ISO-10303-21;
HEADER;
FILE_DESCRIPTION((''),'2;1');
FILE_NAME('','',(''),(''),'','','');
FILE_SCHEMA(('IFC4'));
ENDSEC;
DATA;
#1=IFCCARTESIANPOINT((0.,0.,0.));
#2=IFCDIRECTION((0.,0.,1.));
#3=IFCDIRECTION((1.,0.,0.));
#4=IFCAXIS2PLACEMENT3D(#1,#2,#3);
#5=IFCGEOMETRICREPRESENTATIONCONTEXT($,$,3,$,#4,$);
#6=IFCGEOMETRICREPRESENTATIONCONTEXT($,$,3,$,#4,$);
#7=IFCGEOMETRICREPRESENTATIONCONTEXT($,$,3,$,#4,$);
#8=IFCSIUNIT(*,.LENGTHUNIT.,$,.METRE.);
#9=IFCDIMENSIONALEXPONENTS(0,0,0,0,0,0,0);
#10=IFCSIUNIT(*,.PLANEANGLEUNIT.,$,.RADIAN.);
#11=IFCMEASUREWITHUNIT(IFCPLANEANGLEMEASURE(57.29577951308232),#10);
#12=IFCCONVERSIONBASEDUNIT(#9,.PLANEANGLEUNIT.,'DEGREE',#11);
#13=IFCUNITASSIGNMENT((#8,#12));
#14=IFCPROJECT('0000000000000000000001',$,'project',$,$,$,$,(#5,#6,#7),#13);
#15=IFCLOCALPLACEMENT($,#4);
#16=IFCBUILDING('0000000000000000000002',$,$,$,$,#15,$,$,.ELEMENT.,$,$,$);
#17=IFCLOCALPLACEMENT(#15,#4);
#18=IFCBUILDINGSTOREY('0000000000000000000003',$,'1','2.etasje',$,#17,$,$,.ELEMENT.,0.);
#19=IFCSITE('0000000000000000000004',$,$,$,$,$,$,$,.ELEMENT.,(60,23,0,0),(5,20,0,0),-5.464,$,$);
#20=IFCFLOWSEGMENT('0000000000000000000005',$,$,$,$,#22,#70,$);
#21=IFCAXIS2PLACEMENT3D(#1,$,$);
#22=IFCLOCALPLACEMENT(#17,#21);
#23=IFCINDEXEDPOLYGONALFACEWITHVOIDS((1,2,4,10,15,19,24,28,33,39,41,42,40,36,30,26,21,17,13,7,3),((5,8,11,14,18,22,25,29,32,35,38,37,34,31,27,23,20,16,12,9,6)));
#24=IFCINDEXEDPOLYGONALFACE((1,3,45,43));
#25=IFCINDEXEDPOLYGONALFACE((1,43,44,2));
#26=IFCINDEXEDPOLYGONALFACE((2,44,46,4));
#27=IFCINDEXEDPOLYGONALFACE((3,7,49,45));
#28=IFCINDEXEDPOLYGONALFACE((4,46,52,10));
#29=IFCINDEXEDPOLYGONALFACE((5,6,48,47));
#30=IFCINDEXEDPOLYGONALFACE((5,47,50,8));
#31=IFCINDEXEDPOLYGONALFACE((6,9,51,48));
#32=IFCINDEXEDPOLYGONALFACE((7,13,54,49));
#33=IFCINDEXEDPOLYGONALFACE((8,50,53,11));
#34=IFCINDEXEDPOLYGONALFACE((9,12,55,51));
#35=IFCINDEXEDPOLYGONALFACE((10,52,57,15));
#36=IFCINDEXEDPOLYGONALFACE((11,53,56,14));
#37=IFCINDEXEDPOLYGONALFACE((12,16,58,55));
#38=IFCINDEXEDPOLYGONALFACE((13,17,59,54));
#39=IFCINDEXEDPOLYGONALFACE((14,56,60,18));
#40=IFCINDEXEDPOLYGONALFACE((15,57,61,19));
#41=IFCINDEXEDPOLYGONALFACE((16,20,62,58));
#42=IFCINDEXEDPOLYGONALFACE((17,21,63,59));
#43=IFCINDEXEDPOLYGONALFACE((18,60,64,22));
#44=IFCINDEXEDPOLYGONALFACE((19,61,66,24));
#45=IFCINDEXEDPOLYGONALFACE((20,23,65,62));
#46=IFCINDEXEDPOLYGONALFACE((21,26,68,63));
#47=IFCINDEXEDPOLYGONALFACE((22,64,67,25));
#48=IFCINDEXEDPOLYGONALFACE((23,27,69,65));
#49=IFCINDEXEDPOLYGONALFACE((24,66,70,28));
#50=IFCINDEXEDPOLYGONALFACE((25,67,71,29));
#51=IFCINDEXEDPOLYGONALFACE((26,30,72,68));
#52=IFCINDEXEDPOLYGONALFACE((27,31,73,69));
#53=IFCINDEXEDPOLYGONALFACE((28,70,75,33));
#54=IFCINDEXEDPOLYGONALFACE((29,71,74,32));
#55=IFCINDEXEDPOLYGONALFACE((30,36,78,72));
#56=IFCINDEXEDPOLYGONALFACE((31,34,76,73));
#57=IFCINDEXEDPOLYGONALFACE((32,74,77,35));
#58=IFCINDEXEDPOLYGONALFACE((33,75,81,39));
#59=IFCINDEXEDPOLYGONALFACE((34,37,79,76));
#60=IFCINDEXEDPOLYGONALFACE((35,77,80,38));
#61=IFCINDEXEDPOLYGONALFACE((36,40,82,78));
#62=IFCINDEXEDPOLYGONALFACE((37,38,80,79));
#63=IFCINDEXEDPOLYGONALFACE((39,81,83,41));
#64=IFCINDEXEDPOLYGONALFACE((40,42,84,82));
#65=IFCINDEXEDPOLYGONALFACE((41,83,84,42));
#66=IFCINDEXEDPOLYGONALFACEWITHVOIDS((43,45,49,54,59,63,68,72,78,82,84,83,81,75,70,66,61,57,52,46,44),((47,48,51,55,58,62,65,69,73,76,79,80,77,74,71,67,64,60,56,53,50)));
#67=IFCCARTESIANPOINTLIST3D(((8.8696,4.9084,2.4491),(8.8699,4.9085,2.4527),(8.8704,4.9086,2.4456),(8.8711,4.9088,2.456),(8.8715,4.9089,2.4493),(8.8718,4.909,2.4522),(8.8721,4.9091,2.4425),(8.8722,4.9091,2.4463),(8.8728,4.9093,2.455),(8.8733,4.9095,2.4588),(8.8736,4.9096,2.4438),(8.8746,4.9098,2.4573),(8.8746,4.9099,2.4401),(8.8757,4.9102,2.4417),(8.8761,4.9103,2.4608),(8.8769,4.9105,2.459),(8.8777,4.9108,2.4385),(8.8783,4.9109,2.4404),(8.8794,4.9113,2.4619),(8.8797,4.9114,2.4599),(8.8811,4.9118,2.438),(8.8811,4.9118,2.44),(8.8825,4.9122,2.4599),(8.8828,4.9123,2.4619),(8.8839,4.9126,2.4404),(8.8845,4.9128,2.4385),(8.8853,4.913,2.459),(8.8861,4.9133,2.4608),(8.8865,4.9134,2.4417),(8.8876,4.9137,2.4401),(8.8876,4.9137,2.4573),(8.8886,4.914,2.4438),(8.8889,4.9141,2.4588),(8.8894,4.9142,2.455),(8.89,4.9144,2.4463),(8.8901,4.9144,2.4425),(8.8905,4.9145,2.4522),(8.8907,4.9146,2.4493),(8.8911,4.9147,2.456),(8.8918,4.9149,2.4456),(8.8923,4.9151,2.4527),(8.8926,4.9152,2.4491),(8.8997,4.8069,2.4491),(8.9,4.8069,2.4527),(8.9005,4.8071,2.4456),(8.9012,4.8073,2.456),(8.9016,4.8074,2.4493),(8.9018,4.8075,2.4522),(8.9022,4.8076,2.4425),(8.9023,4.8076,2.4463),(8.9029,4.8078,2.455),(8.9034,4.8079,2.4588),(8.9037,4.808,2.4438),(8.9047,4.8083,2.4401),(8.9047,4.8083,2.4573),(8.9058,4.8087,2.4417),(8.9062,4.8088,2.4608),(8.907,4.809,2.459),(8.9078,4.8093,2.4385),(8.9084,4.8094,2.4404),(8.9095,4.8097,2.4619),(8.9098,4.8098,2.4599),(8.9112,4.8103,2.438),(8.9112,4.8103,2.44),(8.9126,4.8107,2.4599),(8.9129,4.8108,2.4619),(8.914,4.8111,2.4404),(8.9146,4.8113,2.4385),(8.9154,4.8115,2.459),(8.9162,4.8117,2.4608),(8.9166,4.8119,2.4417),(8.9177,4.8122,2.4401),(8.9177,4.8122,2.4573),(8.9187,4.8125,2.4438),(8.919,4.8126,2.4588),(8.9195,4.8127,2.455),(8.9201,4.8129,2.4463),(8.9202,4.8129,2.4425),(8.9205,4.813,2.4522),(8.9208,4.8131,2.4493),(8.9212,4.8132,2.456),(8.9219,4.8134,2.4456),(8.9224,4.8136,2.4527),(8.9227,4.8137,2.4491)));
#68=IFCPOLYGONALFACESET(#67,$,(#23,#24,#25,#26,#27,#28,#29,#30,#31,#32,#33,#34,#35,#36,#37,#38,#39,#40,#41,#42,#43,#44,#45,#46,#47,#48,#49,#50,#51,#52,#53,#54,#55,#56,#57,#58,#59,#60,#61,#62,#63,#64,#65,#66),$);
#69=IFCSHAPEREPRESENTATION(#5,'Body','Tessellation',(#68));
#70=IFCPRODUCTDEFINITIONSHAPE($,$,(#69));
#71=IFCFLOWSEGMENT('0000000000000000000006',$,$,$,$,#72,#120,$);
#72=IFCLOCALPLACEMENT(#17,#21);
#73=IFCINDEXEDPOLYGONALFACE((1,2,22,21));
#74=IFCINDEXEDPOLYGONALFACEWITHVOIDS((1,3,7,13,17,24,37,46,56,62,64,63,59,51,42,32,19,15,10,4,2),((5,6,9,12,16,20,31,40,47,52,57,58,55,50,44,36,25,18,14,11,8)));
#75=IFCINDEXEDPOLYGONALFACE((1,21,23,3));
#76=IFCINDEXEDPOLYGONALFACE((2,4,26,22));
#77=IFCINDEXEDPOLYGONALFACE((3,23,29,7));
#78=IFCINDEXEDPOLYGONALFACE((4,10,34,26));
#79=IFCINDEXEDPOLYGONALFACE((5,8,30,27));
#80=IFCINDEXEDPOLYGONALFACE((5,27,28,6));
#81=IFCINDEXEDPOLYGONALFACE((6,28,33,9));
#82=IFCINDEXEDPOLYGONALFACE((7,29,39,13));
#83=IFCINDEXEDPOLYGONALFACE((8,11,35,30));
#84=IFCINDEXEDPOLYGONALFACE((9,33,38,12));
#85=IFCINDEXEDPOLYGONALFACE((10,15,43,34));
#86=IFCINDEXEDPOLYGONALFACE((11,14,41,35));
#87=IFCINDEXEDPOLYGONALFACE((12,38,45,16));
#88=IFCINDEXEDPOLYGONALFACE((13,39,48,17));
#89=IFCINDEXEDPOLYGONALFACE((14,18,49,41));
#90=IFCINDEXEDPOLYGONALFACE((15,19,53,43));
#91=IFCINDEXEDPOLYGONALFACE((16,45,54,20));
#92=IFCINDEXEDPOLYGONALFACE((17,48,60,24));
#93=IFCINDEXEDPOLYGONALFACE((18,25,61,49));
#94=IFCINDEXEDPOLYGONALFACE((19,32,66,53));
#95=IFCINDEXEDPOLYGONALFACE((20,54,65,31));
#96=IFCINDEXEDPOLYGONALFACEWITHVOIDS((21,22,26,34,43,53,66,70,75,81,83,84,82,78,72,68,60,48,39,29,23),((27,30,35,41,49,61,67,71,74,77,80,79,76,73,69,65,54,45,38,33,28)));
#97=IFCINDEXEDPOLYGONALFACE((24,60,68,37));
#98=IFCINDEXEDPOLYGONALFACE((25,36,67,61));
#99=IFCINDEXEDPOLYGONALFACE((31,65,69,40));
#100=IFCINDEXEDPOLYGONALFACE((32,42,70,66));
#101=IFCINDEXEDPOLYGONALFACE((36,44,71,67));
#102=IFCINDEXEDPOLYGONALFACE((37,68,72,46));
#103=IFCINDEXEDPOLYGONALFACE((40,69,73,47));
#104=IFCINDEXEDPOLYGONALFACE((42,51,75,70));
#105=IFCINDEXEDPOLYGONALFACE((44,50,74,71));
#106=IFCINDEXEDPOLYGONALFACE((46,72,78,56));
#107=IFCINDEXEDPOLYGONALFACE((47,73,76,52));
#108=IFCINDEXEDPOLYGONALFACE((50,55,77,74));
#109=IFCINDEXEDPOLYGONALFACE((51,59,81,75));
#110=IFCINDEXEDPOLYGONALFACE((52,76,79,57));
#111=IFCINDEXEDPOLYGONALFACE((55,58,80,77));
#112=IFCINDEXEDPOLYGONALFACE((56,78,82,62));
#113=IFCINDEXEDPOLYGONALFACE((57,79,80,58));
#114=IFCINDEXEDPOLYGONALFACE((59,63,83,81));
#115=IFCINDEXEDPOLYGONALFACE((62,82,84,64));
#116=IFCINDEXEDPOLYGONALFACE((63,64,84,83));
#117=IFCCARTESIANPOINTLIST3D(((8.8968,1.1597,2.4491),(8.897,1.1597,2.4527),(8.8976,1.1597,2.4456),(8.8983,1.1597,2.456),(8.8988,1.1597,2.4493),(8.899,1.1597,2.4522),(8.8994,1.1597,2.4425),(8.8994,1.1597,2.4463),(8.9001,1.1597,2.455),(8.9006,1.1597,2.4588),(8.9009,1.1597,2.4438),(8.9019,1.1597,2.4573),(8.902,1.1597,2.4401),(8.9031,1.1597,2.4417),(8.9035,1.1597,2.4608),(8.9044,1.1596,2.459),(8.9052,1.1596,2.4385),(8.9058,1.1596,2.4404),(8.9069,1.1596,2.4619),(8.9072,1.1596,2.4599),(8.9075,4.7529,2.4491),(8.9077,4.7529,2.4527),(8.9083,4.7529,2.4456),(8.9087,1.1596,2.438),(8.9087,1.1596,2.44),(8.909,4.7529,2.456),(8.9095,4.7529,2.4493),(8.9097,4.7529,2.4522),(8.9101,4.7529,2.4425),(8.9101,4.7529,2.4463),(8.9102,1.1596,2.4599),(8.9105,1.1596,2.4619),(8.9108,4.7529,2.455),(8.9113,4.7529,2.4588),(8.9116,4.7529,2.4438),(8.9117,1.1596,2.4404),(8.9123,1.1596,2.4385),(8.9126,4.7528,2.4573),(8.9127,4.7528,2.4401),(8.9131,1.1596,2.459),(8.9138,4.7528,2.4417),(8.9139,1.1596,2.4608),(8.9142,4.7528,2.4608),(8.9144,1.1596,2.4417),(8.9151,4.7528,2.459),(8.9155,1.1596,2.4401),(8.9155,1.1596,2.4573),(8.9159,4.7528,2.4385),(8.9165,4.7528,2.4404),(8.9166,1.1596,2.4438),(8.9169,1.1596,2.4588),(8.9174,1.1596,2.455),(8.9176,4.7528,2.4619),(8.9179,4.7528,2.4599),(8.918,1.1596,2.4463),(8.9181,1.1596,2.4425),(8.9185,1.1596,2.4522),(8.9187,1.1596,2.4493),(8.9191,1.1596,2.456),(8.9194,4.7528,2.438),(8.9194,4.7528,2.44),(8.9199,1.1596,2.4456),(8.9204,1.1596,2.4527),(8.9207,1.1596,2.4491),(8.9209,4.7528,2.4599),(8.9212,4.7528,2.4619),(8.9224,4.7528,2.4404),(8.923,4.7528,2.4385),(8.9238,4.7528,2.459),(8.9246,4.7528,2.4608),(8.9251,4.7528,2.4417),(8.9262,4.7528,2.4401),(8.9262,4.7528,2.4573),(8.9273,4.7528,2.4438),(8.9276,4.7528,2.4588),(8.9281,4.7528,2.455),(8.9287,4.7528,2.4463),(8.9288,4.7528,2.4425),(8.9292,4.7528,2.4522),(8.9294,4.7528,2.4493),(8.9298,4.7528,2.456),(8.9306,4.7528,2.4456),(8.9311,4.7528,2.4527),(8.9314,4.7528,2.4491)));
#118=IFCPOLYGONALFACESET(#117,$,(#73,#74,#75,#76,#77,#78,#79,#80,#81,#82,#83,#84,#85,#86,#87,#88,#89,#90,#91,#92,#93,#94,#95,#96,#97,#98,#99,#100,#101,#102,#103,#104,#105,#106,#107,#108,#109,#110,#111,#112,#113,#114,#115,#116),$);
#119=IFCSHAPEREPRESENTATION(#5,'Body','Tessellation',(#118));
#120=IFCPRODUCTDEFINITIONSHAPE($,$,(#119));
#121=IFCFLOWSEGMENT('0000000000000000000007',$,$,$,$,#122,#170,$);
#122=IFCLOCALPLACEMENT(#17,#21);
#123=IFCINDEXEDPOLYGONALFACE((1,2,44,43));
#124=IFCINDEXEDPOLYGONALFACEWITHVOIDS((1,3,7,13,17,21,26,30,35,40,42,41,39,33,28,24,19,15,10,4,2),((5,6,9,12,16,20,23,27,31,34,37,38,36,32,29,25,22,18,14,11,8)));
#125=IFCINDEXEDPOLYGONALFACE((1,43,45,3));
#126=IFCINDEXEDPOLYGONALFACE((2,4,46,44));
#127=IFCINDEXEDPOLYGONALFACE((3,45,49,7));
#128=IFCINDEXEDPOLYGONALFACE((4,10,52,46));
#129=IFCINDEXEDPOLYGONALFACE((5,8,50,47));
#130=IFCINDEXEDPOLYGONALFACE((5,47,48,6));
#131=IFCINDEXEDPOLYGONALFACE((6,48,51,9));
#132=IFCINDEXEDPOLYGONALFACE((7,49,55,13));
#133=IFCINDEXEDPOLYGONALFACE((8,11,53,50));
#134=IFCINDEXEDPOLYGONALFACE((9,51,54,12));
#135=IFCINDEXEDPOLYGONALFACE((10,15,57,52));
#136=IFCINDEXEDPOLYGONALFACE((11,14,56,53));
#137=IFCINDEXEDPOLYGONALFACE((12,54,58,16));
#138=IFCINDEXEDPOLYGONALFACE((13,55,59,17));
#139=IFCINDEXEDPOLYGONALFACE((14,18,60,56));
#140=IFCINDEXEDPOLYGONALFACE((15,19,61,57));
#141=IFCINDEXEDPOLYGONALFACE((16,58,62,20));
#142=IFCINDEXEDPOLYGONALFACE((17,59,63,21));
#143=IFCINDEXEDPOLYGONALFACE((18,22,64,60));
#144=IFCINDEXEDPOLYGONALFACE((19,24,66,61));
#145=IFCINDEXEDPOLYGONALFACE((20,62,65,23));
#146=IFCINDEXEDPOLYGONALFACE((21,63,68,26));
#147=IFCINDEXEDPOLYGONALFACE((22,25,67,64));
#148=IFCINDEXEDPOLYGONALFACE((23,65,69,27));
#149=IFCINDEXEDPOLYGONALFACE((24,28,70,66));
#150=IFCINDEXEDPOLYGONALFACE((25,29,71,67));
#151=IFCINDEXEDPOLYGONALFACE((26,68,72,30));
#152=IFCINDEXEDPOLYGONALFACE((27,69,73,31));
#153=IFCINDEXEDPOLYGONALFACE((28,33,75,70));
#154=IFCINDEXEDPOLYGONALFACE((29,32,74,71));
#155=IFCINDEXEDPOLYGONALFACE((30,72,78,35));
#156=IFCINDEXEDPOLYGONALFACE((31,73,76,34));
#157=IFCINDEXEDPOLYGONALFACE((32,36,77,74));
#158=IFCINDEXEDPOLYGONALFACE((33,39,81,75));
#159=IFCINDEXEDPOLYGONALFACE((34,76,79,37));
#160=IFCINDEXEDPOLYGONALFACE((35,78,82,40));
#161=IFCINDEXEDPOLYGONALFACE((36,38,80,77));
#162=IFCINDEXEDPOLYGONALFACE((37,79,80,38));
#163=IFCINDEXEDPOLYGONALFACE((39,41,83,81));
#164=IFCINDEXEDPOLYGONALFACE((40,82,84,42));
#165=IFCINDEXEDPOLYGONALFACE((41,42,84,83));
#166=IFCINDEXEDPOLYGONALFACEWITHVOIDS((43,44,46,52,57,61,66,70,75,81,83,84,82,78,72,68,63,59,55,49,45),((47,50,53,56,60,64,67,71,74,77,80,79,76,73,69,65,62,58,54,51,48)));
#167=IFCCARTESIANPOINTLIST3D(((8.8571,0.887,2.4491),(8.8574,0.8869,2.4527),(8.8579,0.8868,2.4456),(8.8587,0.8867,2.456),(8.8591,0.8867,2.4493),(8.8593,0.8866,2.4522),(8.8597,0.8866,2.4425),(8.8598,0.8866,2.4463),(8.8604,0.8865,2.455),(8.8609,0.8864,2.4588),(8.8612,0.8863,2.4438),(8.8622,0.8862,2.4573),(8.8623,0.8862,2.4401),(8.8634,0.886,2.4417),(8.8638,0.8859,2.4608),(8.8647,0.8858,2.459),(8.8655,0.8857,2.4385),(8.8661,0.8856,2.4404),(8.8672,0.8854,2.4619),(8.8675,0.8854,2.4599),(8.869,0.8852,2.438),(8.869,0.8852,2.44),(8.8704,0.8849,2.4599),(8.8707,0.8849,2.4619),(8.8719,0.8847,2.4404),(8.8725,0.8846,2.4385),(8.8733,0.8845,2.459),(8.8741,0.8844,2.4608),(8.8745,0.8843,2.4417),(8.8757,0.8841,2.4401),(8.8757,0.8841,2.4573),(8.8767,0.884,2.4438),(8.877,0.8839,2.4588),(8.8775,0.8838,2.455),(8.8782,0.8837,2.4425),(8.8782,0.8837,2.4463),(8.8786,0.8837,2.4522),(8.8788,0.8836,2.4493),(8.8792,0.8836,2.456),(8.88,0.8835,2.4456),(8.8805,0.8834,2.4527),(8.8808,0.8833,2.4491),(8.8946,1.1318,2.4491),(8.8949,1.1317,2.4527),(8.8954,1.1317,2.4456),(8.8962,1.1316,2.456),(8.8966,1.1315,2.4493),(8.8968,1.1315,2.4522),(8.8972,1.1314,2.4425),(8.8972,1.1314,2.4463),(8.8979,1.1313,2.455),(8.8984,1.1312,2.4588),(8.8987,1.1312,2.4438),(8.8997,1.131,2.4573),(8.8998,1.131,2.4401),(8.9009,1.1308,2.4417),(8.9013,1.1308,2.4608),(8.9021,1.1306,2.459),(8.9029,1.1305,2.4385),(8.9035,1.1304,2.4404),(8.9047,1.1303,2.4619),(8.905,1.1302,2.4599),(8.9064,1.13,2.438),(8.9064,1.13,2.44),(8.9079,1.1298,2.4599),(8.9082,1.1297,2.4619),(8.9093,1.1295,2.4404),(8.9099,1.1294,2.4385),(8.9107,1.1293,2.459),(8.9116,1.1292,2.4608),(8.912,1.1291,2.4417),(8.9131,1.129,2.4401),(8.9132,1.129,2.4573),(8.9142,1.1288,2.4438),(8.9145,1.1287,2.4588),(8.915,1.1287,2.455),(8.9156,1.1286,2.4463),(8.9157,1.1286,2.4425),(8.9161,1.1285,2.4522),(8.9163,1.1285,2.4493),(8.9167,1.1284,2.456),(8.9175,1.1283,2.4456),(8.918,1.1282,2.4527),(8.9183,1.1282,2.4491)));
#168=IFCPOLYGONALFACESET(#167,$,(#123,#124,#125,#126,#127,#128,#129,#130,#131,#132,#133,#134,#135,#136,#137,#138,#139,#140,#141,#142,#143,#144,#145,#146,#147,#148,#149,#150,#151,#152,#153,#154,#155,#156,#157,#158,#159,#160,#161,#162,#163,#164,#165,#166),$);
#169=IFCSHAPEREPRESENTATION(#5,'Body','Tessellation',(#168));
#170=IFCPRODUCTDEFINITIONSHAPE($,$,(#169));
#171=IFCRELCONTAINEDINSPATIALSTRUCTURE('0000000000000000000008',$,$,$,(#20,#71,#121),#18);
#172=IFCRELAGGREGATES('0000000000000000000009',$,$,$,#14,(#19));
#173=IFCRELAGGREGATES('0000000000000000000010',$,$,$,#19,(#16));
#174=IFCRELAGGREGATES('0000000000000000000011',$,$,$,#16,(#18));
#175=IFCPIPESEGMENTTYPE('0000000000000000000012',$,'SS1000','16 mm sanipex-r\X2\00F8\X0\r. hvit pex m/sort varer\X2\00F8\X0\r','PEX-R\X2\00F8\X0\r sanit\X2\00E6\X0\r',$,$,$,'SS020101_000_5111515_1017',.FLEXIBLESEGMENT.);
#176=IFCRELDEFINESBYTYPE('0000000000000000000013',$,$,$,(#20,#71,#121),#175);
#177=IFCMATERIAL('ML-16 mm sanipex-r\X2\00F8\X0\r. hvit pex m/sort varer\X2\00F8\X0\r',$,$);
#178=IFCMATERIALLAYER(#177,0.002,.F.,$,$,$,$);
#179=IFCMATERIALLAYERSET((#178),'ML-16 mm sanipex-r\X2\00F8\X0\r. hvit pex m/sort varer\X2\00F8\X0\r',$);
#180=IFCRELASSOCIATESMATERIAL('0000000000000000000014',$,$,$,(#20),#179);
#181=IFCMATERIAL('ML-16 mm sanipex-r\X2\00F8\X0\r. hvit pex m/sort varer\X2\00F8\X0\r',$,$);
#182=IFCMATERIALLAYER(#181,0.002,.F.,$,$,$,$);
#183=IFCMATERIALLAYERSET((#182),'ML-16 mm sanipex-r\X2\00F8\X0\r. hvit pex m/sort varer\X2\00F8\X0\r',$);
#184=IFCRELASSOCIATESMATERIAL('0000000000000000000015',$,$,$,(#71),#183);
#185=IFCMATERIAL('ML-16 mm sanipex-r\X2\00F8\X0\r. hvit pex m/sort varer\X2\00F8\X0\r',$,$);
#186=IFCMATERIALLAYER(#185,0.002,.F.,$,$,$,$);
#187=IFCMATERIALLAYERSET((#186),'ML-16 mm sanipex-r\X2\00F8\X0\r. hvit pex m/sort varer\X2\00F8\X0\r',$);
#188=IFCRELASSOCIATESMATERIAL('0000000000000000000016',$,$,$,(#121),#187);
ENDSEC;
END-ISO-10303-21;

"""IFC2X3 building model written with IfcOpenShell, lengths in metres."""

from ifc_helpers import new_model, entity, si_unit, converted_unit, frame, origin_with_axes, origin_2d_with_axis, place, context, project, spatial, hollow_circle, extrude, material, layer, layer_set, layer_usage, type_object, element, save


model = new_model("IFC2X3")

# Units and contexts
context_of_model_1 = context(None, 3, world=origin_with_axes())
context_of_model_2 = context(None, 3, world=origin_with_axes())
context_of_model_3 = context(None, 3, world=origin_with_axes())
ifc_project = project(units=[si_unit("LENGTHUNIT", "METRE"), converted_unit("PLANEANGLEUNIT", "DEGREE", entity("IfcPlaneAngleMeasure", 57.29577951308232), si_unit("PLANEANGLEUNIT", "RADIAN"), dimensions=[0, 0, 0, 0, 0, 0, 0])], contexts=[context_of_model_1, context_of_model_2, context_of_model_3])

# Site, building, storey
site = spatial("IfcSite", under=ifc_project, CompositionType="ELEMENT", RefLatitude=(60, 23, 0, 0), RefLongitude=(5, 20, 0, 0), RefElevation=-5.464)
building_placement = place(None, origin_with_axes())
building = spatial("IfcBuilding", under=site, at=building_placement, CompositionType="ELEMENT")
storey_placement = place(building_placement, origin_with_axes())
storey = spatial("IfcBuildingStorey", under=building, at=storey_placement, Name="1", Description="2.etasje", CompositionType="ELEMENT", Elevation=0.0)

# Flow segments
pipe_segment_type_1 = type_object("IfcPipeSegmentType", Name="SS1000", Description="16 mm sanipex-rør. hvit pex m/sort varerør", ApplicableOccurrence="PEX-Rør sanitær", ElementType="SS020101_000_5111515_1017", PredefinedType="FLEXIBLESEGMENT")
ifc_material_1 = material(Name="ML-16 mm sanipex-rør. hvit pex m/sort varerør")
ifc_layer_1 = layer(ifc_material_1, 0.002, ventilated=False)
ifc_layer_set_1 = layer_set([ifc_layer_1], Name="ML-16 mm sanipex-rør. hvit pex m/sort varerør")
ifc_layer_usage_1 = layer_usage(ifc_layer_set_1, "AXIS2", "POSITIVE", 0.0)
flow_segment_1_placement = place(storey_placement, frame((8.8811, 4.9118, 2.45), z_axis=(0.284164, -0.958776, 0.0), x_axis=(0.0, 0.0, -1.0)))
element("IfcFlowSegment", 1, at=flow_segment_1_placement, inside=storey, type_object=pipe_segment_type_1, material=ifc_layer_usage_1, context=context_of_model_1, shape_type="SweptSolid", body=[
    extrude(hollow_circle(Radius=0.012, WallThickness=0.002, at=origin_2d_with_axis()), origin_with_axes(), (0.0, 0.0, 1.0), 0.1059),
])
ifc_material_2 = material(Name="ML-16 mm sanipex-rør. hvit pex m/sort varerør")
ifc_layer_2 = layer(ifc_material_2, 0.002, ventilated=False)
ifc_layer_set_2 = layer_set([ifc_layer_2], Name="ML-16 mm sanipex-rør. hvit pex m/sort varerør")
ifc_layer_usage_2 = layer_usage(ifc_layer_set_2, "AXIS2", "POSITIVE", 0.0)
flow_segment_2_placement = place(storey_placement, frame((8.9194, 4.7528, 2.45), z_axis=(-0.002978, -0.999996, 0.0), x_axis=(0.0, 0.0, -1.0)))
element("IfcFlowSegment", 2, at=flow_segment_2_placement, inside=storey, type_object=pipe_segment_type_1, material=ifc_layer_usage_2, context=context_of_model_1, shape_type="SweptSolid", body=[
    extrude(hollow_circle(Radius=0.012, WallThickness=0.002, at=origin_2d_with_axis()), origin_with_axes(), (0.0, 0.0, 1.0), 3.5932),
])
ifc_material_3 = material(Name="ML-16 mm sanipex-rør. hvit pex m/sort varerør")
ifc_layer_3 = layer(ifc_material_3, 0.002, ventilated=False)
ifc_layer_set_3 = layer_set([ifc_layer_3], Name="ML-16 mm sanipex-rør. hvit pex m/sort varerør")
ifc_layer_usage_3 = layer_usage(ifc_layer_set_3, "AXIS2", "POSITIVE", 0.0)
flow_segment_3_placement = place(storey_placement, frame((8.9064, 1.13, 2.45), z_axis=(-0.151254, -0.988495, 0.0), x_axis=(0.0, 0.0, -1.0)))
element("IfcFlowSegment", 3, at=flow_segment_3_placement, inside=storey, type_object=pipe_segment_type_1, material=ifc_layer_usage_3, context=context_of_model_1, shape_type="SweptSolid", body=[
    extrude(hollow_circle(Radius=0.012, WallThickness=0.002, at=origin_2d_with_axis()), origin_with_axes(), (0.0, 0.0, 1.0), 0.2477),
])

save(model, "model.ifc")
